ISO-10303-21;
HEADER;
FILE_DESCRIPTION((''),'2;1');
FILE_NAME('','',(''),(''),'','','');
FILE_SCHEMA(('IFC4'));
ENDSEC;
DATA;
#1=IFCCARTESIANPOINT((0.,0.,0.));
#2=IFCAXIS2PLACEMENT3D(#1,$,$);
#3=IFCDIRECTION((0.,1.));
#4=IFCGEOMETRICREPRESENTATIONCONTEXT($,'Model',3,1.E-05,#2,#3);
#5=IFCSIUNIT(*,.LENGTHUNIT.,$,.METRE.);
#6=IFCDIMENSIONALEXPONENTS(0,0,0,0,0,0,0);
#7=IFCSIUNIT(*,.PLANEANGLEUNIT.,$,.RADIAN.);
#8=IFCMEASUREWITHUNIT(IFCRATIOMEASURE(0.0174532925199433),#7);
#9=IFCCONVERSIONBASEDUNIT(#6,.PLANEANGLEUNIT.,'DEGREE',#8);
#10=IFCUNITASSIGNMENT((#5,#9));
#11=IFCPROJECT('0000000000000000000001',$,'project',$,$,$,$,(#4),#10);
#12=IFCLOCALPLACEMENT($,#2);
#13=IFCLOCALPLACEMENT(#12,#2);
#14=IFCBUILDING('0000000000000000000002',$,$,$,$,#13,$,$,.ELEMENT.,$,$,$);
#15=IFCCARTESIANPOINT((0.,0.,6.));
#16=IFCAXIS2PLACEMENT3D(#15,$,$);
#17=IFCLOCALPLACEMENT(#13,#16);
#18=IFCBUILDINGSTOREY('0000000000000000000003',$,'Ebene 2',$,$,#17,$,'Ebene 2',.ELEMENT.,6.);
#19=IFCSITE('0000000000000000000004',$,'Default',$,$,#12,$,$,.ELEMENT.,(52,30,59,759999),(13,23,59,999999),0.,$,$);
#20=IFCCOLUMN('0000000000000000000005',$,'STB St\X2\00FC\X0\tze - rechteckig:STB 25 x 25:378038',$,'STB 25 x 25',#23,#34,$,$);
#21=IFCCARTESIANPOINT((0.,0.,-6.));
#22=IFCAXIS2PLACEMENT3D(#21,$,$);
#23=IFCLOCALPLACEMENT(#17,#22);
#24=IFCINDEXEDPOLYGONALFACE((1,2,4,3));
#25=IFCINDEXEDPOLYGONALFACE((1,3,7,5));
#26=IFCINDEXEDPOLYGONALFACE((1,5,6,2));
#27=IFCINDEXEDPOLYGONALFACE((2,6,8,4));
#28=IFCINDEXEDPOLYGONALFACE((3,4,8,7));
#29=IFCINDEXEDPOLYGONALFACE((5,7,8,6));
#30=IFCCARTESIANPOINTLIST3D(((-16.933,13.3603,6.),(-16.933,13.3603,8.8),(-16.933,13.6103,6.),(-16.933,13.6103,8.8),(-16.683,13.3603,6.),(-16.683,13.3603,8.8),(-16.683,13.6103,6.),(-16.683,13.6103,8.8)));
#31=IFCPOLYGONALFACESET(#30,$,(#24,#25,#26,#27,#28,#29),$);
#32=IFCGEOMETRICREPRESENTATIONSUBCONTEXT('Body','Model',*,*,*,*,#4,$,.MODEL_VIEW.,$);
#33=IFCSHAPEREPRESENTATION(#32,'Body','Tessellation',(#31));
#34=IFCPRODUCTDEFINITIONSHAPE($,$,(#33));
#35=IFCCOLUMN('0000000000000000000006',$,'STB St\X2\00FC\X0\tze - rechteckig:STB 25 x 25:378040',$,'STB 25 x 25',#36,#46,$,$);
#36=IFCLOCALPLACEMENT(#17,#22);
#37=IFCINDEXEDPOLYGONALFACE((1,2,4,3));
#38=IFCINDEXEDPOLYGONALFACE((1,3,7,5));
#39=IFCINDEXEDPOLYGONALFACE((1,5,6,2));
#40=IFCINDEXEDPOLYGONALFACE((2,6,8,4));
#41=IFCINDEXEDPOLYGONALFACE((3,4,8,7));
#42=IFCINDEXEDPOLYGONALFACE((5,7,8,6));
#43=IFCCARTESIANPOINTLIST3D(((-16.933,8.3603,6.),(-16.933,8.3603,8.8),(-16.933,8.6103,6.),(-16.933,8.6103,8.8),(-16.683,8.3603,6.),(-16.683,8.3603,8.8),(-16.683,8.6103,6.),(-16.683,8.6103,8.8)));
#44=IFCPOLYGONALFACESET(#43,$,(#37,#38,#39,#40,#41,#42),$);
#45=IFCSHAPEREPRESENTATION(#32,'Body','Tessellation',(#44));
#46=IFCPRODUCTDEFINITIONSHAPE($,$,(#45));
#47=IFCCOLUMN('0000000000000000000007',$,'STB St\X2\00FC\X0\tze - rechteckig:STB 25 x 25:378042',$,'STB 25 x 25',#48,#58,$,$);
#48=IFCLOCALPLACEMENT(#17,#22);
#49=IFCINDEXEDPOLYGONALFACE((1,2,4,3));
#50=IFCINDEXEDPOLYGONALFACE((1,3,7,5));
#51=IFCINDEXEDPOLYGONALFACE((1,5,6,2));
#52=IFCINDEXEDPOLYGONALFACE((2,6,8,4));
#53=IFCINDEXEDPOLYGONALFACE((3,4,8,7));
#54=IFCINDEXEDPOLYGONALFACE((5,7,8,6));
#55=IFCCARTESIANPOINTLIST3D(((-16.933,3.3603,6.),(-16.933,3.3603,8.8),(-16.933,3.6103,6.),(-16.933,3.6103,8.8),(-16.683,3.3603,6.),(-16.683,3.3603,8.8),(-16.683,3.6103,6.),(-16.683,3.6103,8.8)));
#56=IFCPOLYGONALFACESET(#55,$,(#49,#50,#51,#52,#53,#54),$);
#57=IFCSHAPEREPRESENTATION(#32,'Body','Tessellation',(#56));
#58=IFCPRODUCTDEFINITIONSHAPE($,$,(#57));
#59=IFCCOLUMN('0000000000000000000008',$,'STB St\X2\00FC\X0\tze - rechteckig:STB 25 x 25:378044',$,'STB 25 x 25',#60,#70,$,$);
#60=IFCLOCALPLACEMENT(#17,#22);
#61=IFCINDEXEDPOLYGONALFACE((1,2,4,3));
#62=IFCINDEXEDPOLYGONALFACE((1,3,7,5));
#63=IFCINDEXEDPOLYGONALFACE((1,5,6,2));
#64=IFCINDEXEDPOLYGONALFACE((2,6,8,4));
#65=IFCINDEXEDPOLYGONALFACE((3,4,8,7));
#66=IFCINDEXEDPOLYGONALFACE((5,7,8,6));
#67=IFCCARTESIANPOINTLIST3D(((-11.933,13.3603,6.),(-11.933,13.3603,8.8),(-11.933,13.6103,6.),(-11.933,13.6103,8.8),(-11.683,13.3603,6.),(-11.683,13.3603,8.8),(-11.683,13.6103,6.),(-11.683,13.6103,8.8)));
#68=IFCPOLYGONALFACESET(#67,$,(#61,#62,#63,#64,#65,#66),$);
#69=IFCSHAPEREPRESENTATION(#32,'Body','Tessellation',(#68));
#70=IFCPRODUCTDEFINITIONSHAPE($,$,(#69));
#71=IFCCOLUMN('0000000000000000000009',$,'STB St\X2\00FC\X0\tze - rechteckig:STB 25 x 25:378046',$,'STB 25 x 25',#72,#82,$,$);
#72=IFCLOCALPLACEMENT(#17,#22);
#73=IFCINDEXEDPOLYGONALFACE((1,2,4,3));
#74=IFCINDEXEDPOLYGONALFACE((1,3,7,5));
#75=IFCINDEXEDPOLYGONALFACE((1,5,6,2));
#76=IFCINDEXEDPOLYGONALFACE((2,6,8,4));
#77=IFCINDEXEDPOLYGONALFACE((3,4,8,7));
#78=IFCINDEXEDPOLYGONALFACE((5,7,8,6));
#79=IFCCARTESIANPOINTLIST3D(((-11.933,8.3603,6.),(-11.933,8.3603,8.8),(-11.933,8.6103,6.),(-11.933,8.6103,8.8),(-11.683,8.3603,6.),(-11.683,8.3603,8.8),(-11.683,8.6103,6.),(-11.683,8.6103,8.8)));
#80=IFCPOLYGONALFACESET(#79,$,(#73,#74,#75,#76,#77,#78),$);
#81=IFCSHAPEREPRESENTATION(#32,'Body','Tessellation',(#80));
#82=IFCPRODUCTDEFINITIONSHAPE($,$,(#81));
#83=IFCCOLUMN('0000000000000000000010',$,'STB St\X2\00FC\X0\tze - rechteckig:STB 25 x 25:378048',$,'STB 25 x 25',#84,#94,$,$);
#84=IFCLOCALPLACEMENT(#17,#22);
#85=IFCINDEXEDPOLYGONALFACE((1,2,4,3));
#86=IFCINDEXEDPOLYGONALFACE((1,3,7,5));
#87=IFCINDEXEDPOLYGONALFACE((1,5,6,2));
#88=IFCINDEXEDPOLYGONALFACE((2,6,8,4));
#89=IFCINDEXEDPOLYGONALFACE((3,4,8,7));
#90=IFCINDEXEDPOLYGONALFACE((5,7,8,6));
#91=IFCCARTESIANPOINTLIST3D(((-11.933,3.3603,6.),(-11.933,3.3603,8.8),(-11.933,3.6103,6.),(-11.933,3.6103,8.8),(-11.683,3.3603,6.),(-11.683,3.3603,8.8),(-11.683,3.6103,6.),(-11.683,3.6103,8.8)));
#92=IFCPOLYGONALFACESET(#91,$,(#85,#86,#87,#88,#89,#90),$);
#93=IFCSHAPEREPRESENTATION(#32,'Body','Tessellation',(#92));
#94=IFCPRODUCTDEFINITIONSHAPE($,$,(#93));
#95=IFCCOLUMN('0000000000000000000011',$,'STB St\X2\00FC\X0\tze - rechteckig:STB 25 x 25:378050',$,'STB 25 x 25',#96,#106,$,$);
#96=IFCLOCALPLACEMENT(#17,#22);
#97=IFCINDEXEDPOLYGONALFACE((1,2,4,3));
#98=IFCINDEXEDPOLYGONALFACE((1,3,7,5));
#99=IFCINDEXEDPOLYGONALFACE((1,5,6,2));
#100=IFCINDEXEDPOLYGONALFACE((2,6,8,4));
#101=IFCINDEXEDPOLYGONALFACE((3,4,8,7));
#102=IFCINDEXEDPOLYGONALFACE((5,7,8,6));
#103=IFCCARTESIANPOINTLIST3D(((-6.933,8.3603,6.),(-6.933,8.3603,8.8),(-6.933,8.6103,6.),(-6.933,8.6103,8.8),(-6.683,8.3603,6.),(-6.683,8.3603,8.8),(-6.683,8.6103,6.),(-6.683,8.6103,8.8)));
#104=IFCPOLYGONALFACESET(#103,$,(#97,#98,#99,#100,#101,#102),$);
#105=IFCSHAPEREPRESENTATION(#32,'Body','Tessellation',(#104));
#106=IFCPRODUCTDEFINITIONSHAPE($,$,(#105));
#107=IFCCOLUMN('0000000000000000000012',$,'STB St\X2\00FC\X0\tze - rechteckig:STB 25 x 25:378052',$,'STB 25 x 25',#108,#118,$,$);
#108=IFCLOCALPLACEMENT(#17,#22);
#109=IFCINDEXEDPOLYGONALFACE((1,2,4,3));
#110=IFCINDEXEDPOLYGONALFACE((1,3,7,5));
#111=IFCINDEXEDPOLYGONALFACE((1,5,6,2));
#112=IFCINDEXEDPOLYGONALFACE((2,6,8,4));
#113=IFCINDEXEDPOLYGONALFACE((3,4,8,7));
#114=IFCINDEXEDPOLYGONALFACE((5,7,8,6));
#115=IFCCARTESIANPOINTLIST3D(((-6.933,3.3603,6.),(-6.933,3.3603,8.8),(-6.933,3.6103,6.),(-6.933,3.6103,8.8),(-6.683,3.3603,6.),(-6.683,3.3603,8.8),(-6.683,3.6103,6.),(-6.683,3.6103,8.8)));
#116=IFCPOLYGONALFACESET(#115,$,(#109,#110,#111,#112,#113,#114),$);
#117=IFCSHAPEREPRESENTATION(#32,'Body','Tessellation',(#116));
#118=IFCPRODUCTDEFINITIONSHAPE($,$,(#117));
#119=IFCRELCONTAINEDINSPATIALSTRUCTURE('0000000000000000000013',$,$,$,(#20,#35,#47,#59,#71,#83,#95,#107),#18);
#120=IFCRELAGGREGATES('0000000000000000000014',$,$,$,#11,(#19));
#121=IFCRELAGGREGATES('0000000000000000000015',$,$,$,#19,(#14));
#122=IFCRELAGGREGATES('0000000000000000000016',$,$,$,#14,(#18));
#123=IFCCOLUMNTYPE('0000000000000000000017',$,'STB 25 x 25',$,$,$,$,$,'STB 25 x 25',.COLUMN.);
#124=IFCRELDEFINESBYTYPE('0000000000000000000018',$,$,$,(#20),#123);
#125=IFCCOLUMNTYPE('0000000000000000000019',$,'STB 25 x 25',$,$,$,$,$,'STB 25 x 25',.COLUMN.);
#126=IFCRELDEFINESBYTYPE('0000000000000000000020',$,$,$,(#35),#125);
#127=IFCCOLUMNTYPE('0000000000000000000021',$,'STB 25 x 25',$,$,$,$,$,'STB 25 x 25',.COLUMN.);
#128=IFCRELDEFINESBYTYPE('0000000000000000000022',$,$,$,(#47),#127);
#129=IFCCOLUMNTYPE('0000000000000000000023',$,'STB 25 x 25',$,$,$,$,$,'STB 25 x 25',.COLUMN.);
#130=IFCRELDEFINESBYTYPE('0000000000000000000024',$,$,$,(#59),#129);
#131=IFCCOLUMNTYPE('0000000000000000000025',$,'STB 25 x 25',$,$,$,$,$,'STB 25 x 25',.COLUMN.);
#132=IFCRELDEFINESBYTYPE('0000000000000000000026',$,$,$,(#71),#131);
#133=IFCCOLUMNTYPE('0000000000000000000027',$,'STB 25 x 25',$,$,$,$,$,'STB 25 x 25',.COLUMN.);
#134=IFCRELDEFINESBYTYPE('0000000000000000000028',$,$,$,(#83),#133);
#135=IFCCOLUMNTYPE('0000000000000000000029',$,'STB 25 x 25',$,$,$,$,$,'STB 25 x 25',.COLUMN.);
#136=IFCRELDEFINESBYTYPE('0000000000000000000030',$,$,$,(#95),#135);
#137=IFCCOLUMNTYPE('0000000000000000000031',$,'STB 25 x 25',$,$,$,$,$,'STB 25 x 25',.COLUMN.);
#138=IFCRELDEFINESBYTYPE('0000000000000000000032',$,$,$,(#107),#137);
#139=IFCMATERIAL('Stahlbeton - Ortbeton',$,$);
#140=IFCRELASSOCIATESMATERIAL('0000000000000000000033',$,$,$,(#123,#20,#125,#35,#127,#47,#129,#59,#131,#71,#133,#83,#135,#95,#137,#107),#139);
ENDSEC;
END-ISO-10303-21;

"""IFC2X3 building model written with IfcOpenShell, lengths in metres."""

from ifc_helpers import new_model, entity, si_unit, converted_unit, direction, frame, frame_2d, origin, origin_2d_with_axis, place, context, subcontext, project, spatial, rectangle, extrude, source, transform, mapped, material, type_object, type_shapes, element, save


model = new_model("IFC2X3")

# Units and contexts
model_context = context("Model", 3, precision=1e-05, world=origin(), true_north=direction((0.0, 1.0)))
body_context = subcontext(model_context, "Body", "Model", "MODEL_VIEW")
ifc_project = project(units=[si_unit("LENGTHUNIT", "METRE"), converted_unit("PLANEANGLEUNIT", "DEGREE", entity("IfcRatioMeasure", 0.0174532925199433), si_unit("PLANEANGLEUNIT", "RADIAN"), dimensions=[0, 0, 0, 0, 0, 0, 0])], contexts=[model_context])

# Site, building, storey
site_placement = place(None, origin())
site = spatial("IfcSite", under=ifc_project, at=site_placement, Name="Default", CompositionType="ELEMENT", RefLatitude=(52, 30, 59, 759999), RefLongitude=(13, 23, 59, 999999), RefElevation=0.0)
building_placement = place(site_placement, origin())
building = spatial("IfcBuilding", under=site, at=building_placement, CompositionType="ELEMENT")
storey_placement = place(building_placement, frame((0.0, 0.0, 6.0)))
storey = spatial("IfcBuildingStorey", under=building, at=storey_placement, Name="Ebene 2", LongName="Ebene 2", CompositionType="ELEMENT", Elevation=6.0)

# Columns
ifc_material_1 = material(Name="Stahlbeton - Ortbeton")
column_type_1 = type_object("IfcColumnType", Name="STB 25 x 25", ElementType="STB 25 x 25", PredefinedType="COLUMN", material=ifc_material_1)
shared_shape_1 = source(origin(), body_context, "Body", "SweptSolid", [
    extrude(rectangle(XDim=0.25, YDim=0.25, at=origin_2d_with_axis()), frame((-16.808, 13.4853, 6.0), z_axis=(0.0, 0.0, 1.0), x_axis=(0.0, -1.0, 0.0)), (0.0, 0.0, 1.0), 2.8),
])
type_shapes(column_type_1, [shared_shape_1])
column_1_placement = place(storey_placement, frame((0.0, 0.0, -6.0)))
element("IfcColumn", 1, at=column_1_placement, inside=storey, type_object=column_type_1, material=ifc_material_1, Name="STB Stütze - rechteckig:STB 25 x 25:378038", ObjectType="STB 25 x 25", context=body_context, shape_type="MappedRepresentation", body=[
    mapped(shared_shape_1, transform((0.0, 0.0, 0.0), scale=1.0)),
])
column_type_2 = type_object("IfcColumnType", Name="STB 25 x 25", ElementType="STB 25 x 25", PredefinedType="COLUMN", material=ifc_material_1)
shared_shape_2 = source(origin(), body_context, "Body", "SweptSolid", [
    extrude(rectangle(XDim=0.25, YDim=0.25, at=origin_2d_with_axis()), frame((-16.808, 8.4853, 6.0), z_axis=(0.0, 0.0, 1.0), x_axis=(0.0, -1.0, 0.0)), (0.0, 0.0, 1.0), 2.8),
])
type_shapes(column_type_2, [shared_shape_2])
column_2_placement = place(storey_placement, frame((0.0, 0.0, -6.0)))
element("IfcColumn", 2, at=column_2_placement, inside=storey, type_object=column_type_2, material=ifc_material_1, Name="STB Stütze - rechteckig:STB 25 x 25:378040", ObjectType="STB 25 x 25", context=body_context, shape_type="MappedRepresentation", body=[
    mapped(shared_shape_2, transform((0.0, 0.0, 0.0), scale=1.0)),
])
column_type_3 = type_object("IfcColumnType", Name="STB 25 x 25", ElementType="STB 25 x 25", PredefinedType="COLUMN", material=ifc_material_1)
shared_shape_3 = source(origin(), body_context, "Body", "SweptSolid", [
    extrude(rectangle(XDim=0.25, YDim=0.25, at=frame_2d((0.0, 0.0), x_axis=(1.0, 0.0))), frame((-16.808, 3.4853, 6.0), z_axis=(0.0, 0.0, 1.0), x_axis=(0.0, -1.0, 0.0)), (0.0, 0.0, 1.0), 2.8),
])
type_shapes(column_type_3, [shared_shape_3])
column_3_placement = place(storey_placement, frame((0.0, 0.0, -6.0)))
element("IfcColumn", 3, at=column_3_placement, inside=storey, type_object=column_type_3, material=ifc_material_1, Name="STB Stütze - rechteckig:STB 25 x 25:378042", ObjectType="STB 25 x 25", context=body_context, shape_type="MappedRepresentation", body=[
    mapped(shared_shape_3, transform((0.0, 0.0, 0.0), scale=1.0)),
])
column_type_4 = type_object("IfcColumnType", Name="STB 25 x 25", ElementType="STB 25 x 25", PredefinedType="COLUMN", material=ifc_material_1)
shared_shape_4 = source(origin(), body_context, "Body", "SweptSolid", [
    extrude(rectangle(XDim=0.25, YDim=0.25, at=origin_2d_with_axis()), frame((-11.808, 13.4853, 6.0), z_axis=(0.0, 0.0, 1.0), x_axis=(0.0, -1.0, 0.0)), (0.0, 0.0, 1.0), 2.8),
])
type_shapes(column_type_4, [shared_shape_4])
column_4_placement = place(storey_placement, frame((0.0, 0.0, -6.0)))
element("IfcColumn", 4, at=column_4_placement, inside=storey, type_object=column_type_4, material=ifc_material_1, Name="STB Stütze - rechteckig:STB 25 x 25:378044", ObjectType="STB 25 x 25", context=body_context, shape_type="MappedRepresentation", body=[
    mapped(shared_shape_4, transform((0.0, 0.0, 0.0), scale=1.0)),
])
column_type_5 = type_object("IfcColumnType", Name="STB 25 x 25", ElementType="STB 25 x 25", PredefinedType="COLUMN", material=ifc_material_1)
shared_shape_5 = source(origin(), body_context, "Body", "SweptSolid", [
    extrude(rectangle(XDim=0.25, YDim=0.25, at=origin_2d_with_axis()), frame((-11.808, 8.4853, 6.0), z_axis=(0.0, 0.0, 1.0), x_axis=(0.0, -1.0, 0.0)), (0.0, 0.0, 1.0), 2.8),
])
type_shapes(column_type_5, [shared_shape_5])
column_5_placement = place(storey_placement, frame((0.0, 0.0, -6.0)))
element("IfcColumn", 5, at=column_5_placement, inside=storey, type_object=column_type_5, material=ifc_material_1, Name="STB Stütze - rechteckig:STB 25 x 25:378046", ObjectType="STB 25 x 25", context=body_context, shape_type="MappedRepresentation", body=[
    mapped(shared_shape_5, transform((0.0, 0.0, 0.0), scale=1.0)),
])
column_type_6 = type_object("IfcColumnType", Name="STB 25 x 25", ElementType="STB 25 x 25", PredefinedType="COLUMN", material=ifc_material_1)
shared_shape_6 = source(origin(), body_context, "Body", "SweptSolid", [
    extrude(rectangle(XDim=0.25, YDim=0.25, at=frame_2d((0.0, 0.0), x_axis=(1.0, 0.0))), frame((-11.808, 3.4853, 6.0), z_axis=(0.0, 0.0, 1.0), x_axis=(0.0, -1.0, 0.0)), (0.0, 0.0, 1.0), 2.8),
])
type_shapes(column_type_6, [shared_shape_6])
column_6_placement = place(storey_placement, frame((0.0, 0.0, -6.0)))
element("IfcColumn", 6, at=column_6_placement, inside=storey, type_object=column_type_6, material=ifc_material_1, Name="STB Stütze - rechteckig:STB 25 x 25:378048", ObjectType="STB 25 x 25", context=body_context, shape_type="MappedRepresentation", body=[
    mapped(shared_shape_6, transform((0.0, 0.0, 0.0), scale=1.0)),
])
column_type_7 = type_object("IfcColumnType", Name="STB 25 x 25", ElementType="STB 25 x 25", PredefinedType="COLUMN", material=ifc_material_1)
shared_shape_7 = source(origin(), body_context, "Body", "SweptSolid", [
    extrude(rectangle(XDim=0.25, YDim=0.25, at=origin_2d_with_axis()), frame((-6.808, 8.4853, 6.0), z_axis=(0.0, 0.0, 1.0), x_axis=(0.0, -1.0, 0.0)), (0.0, 0.0, 1.0), 2.8),
])
type_shapes(column_type_7, [shared_shape_7])
column_7_placement = place(storey_placement, frame((0.0, 0.0, -6.0)))
element("IfcColumn", 7, at=column_7_placement, inside=storey, type_object=column_type_7, material=ifc_material_1, Name="STB Stütze - rechteckig:STB 25 x 25:378050", ObjectType="STB 25 x 25", context=body_context, shape_type="MappedRepresentation", body=[
    mapped(shared_shape_7, transform((0.0, 0.0, 0.0), scale=1.0)),
])
column_type_8 = type_object("IfcColumnType", Name="STB 25 x 25", ElementType="STB 25 x 25", PredefinedType="COLUMN", material=ifc_material_1)
shared_shape_8 = source(origin(), body_context, "Body", "SweptSolid", [
    extrude(rectangle(XDim=0.25, YDim=0.25, at=frame_2d((0.0, 0.0), x_axis=(1.0, 0.0))), frame((-6.808, 3.4853, 6.0), z_axis=(0.0, 0.0, 1.0), x_axis=(0.0, -1.0, 0.0)), (0.0, 0.0, 1.0), 2.8),
])
type_shapes(column_type_8, [shared_shape_8])
column_8_placement = place(storey_placement, frame((0.0, 0.0, -6.0)))
element("IfcColumn", 8, at=column_8_placement, inside=storey, type_object=column_type_8, material=ifc_material_1, Name="STB Stütze - rechteckig:STB 25 x 25:378052", ObjectType="STB 25 x 25", context=body_context, shape_type="MappedRepresentation", body=[
    mapped(shared_shape_8, transform((0.0, 0.0, 0.0), scale=1.0)),
])

save(model, "model.ifc")
